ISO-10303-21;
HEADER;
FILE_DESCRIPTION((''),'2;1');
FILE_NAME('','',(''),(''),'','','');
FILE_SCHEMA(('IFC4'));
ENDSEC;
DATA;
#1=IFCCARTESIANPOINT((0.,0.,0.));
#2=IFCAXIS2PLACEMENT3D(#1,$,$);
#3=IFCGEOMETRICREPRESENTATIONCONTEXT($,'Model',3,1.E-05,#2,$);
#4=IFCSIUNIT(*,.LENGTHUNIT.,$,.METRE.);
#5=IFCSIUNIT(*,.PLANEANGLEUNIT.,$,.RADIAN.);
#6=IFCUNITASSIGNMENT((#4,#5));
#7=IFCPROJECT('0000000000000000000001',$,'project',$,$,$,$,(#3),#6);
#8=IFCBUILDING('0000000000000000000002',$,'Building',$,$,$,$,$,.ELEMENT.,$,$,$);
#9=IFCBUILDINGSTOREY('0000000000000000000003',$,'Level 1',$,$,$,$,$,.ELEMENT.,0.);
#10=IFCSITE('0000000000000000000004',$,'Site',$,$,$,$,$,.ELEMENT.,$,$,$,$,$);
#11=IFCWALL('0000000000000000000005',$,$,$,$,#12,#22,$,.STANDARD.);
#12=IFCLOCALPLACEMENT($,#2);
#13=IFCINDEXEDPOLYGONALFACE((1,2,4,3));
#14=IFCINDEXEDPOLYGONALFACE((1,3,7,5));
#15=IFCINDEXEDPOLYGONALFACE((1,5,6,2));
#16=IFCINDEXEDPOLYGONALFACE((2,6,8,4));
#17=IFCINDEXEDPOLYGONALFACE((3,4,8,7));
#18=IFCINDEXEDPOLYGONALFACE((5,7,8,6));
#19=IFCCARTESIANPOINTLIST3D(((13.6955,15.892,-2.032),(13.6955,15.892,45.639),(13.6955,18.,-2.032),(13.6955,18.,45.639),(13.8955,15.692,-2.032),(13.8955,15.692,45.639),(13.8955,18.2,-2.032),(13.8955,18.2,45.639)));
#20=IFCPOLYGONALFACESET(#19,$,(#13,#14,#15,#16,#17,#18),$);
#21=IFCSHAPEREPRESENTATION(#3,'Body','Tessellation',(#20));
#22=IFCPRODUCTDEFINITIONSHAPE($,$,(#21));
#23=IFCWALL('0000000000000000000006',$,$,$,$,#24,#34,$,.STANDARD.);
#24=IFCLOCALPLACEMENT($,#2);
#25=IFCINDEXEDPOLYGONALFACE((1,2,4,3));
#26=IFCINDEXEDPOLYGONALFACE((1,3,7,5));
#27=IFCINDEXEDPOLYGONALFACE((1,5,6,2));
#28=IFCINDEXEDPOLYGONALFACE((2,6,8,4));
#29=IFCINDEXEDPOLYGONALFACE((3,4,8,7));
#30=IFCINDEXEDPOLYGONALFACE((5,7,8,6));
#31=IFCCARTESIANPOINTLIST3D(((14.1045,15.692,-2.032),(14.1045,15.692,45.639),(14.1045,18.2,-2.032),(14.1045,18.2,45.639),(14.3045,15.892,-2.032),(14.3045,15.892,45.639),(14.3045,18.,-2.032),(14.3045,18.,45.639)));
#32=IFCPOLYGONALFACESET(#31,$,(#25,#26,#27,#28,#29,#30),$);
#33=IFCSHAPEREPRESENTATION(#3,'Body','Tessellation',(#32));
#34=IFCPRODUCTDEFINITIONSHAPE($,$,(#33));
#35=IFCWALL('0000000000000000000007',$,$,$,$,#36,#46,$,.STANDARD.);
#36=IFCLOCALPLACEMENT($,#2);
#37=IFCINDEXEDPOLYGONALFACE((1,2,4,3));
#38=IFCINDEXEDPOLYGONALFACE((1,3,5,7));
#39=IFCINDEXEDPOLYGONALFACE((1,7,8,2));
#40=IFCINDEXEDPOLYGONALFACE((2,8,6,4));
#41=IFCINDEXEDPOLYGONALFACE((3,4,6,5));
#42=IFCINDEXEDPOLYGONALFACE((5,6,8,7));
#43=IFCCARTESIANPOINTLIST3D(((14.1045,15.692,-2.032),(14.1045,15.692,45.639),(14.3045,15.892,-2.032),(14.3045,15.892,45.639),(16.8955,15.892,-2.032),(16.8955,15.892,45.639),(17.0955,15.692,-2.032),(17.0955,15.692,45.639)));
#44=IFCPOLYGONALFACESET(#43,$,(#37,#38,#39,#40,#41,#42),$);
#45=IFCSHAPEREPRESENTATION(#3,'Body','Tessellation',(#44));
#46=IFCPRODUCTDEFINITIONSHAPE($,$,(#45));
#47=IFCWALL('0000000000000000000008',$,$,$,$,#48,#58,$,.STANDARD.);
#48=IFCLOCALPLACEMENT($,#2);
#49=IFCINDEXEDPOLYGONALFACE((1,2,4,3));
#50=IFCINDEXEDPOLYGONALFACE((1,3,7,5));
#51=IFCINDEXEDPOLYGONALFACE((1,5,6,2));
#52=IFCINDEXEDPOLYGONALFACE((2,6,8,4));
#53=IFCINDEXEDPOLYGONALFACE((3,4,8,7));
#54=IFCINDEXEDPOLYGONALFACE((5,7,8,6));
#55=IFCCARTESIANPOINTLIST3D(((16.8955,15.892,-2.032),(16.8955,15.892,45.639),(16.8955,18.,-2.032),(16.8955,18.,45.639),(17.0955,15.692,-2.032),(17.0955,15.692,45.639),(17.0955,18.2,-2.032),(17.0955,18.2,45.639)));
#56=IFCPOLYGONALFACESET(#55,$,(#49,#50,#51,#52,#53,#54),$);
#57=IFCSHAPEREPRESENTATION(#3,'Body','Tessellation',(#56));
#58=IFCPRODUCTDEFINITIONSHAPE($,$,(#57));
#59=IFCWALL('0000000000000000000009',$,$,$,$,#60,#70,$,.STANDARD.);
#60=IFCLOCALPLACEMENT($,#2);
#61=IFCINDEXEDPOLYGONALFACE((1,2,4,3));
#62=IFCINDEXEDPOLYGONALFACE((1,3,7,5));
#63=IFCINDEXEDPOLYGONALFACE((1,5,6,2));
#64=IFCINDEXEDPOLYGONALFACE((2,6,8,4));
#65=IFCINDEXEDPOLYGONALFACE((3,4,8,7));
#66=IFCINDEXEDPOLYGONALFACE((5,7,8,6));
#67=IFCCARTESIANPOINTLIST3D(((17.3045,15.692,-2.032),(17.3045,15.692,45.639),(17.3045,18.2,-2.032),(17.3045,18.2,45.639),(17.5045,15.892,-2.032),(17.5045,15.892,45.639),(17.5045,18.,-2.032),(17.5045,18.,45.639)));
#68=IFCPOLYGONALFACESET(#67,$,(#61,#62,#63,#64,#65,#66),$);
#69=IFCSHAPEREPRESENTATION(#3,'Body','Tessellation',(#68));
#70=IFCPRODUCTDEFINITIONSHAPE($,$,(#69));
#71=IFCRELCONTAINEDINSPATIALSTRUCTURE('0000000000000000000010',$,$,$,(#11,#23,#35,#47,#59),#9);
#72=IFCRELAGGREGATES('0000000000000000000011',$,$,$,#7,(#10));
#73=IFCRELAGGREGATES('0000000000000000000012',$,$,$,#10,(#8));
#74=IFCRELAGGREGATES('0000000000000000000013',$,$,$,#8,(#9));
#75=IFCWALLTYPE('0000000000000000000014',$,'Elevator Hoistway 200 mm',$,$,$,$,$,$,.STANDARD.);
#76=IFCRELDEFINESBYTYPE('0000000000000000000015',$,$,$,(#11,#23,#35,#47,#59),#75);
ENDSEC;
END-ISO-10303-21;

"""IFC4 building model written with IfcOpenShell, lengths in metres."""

from ifc_helpers import new_model, si_unit, frame, origin, place, context, project, spatial, polyline, outline, extrude, type_object, element, save


model = new_model("IFC4")

# Units and contexts
model_context = context("Model", 3, precision=1e-05, world=origin())
ifc_project = project(units=[si_unit("LENGTHUNIT", "METRE"), si_unit("PLANEANGLEUNIT", "RADIAN")], contexts=[model_context])

# Site, building, storey
site = spatial("IfcSite", under=ifc_project, Name="Site", CompositionType="ELEMENT")
building = spatial("IfcBuilding", under=site, Name="Building", CompositionType="ELEMENT")
storey = spatial("IfcBuildingStorey", under=building, Name="Level 1", CompositionType="ELEMENT", Elevation=0.0)

# Wall
wall_type = type_object("IfcWallType", Name="Elevator Hoistway 200 mm", PredefinedType="STANDARD")
wall_1_placement = place(None, frame((13.7955, 15.792, -2.032), z_axis=(0.0, 0.0, 1.0), x_axis=(0.0, 1.0, 0.0)))
element("IfcWall", 1, at=wall_1_placement, inside=storey, type_object=wall_type, PredefinedType="STANDARD", context=model_context, shape_type="SweptSolid", body=[
    extrude(outline(polyline([(-0.1, -0.1), (2.408, -0.1), (2.208, 0.1), (0.1, 0.1), (-0.1, -0.1)])), origin(), (0.0, 0.0, 1.0), 47.671),
])

# Walls
wall_2_placement = place(None, frame((14.2045, 18.1, -2.032), z_axis=(0.0, 0.0, 1.0), x_axis=(0.0, -1.0, 0.0)))
element("IfcWall", 2, at=wall_2_placement, inside=storey, type_object=wall_type, PredefinedType="STANDARD", context=model_context, shape_type="SweptSolid", body=[
    extrude(outline(polyline([(-0.1, -0.1), (2.408, -0.1), (2.208, 0.1), (0.1, 0.1), (-0.1, -0.1)])), origin(), (0.0, 0.0, 1.0), 47.671),
])
wall_3_placement = place(None, frame((14.2045, 15.792, -2.032), z_axis=(0.0, 0.0, 1.0), x_axis=(1.0, 0.0, 0.0)))
element("IfcWall", 3, at=wall_3_placement, inside=storey, type_object=wall_type, PredefinedType="STANDARD", context=model_context, shape_type="SweptSolid", body=[
    extrude(outline(polyline([(-0.1, -0.1), (2.891, -0.1), (2.691, 0.1), (0.1, 0.1), (-0.1, -0.1)])), origin(), (0.0, 0.0, 1.0), 47.671),
])
wall_4_placement = place(None, frame((16.9955, 15.792, -2.032), z_axis=(0.0, 0.0, 1.0), x_axis=(0.0, 1.0, 0.0)))
element("IfcWall", 4, at=wall_4_placement, inside=storey, type_object=wall_type, PredefinedType="STANDARD", context=model_context, shape_type="SweptSolid", body=[
    extrude(outline(polyline([(-0.1, -0.1), (2.408, -0.1), (2.208, 0.1), (0.1, 0.1), (-0.1, -0.1)])), origin(), (0.0, 0.0, 1.0), 47.671),
])
wall_5_placement = place(None, frame((17.4045, 18.1, -2.032), z_axis=(0.0, 0.0, 1.0), x_axis=(0.0, -1.0, 0.0)))
element("IfcWall", 5, at=wall_5_placement, inside=storey, type_object=wall_type, PredefinedType="STANDARD", context=model_context, shape_type="SweptSolid", body=[
    extrude(outline(polyline([(-0.1, -0.1), (2.408, -0.1), (2.208, 0.1), (0.1, 0.1), (-0.1, -0.1)])), origin(), (0.0, 0.0, 1.0), 47.671),
])

save(model, "model.ifc")
